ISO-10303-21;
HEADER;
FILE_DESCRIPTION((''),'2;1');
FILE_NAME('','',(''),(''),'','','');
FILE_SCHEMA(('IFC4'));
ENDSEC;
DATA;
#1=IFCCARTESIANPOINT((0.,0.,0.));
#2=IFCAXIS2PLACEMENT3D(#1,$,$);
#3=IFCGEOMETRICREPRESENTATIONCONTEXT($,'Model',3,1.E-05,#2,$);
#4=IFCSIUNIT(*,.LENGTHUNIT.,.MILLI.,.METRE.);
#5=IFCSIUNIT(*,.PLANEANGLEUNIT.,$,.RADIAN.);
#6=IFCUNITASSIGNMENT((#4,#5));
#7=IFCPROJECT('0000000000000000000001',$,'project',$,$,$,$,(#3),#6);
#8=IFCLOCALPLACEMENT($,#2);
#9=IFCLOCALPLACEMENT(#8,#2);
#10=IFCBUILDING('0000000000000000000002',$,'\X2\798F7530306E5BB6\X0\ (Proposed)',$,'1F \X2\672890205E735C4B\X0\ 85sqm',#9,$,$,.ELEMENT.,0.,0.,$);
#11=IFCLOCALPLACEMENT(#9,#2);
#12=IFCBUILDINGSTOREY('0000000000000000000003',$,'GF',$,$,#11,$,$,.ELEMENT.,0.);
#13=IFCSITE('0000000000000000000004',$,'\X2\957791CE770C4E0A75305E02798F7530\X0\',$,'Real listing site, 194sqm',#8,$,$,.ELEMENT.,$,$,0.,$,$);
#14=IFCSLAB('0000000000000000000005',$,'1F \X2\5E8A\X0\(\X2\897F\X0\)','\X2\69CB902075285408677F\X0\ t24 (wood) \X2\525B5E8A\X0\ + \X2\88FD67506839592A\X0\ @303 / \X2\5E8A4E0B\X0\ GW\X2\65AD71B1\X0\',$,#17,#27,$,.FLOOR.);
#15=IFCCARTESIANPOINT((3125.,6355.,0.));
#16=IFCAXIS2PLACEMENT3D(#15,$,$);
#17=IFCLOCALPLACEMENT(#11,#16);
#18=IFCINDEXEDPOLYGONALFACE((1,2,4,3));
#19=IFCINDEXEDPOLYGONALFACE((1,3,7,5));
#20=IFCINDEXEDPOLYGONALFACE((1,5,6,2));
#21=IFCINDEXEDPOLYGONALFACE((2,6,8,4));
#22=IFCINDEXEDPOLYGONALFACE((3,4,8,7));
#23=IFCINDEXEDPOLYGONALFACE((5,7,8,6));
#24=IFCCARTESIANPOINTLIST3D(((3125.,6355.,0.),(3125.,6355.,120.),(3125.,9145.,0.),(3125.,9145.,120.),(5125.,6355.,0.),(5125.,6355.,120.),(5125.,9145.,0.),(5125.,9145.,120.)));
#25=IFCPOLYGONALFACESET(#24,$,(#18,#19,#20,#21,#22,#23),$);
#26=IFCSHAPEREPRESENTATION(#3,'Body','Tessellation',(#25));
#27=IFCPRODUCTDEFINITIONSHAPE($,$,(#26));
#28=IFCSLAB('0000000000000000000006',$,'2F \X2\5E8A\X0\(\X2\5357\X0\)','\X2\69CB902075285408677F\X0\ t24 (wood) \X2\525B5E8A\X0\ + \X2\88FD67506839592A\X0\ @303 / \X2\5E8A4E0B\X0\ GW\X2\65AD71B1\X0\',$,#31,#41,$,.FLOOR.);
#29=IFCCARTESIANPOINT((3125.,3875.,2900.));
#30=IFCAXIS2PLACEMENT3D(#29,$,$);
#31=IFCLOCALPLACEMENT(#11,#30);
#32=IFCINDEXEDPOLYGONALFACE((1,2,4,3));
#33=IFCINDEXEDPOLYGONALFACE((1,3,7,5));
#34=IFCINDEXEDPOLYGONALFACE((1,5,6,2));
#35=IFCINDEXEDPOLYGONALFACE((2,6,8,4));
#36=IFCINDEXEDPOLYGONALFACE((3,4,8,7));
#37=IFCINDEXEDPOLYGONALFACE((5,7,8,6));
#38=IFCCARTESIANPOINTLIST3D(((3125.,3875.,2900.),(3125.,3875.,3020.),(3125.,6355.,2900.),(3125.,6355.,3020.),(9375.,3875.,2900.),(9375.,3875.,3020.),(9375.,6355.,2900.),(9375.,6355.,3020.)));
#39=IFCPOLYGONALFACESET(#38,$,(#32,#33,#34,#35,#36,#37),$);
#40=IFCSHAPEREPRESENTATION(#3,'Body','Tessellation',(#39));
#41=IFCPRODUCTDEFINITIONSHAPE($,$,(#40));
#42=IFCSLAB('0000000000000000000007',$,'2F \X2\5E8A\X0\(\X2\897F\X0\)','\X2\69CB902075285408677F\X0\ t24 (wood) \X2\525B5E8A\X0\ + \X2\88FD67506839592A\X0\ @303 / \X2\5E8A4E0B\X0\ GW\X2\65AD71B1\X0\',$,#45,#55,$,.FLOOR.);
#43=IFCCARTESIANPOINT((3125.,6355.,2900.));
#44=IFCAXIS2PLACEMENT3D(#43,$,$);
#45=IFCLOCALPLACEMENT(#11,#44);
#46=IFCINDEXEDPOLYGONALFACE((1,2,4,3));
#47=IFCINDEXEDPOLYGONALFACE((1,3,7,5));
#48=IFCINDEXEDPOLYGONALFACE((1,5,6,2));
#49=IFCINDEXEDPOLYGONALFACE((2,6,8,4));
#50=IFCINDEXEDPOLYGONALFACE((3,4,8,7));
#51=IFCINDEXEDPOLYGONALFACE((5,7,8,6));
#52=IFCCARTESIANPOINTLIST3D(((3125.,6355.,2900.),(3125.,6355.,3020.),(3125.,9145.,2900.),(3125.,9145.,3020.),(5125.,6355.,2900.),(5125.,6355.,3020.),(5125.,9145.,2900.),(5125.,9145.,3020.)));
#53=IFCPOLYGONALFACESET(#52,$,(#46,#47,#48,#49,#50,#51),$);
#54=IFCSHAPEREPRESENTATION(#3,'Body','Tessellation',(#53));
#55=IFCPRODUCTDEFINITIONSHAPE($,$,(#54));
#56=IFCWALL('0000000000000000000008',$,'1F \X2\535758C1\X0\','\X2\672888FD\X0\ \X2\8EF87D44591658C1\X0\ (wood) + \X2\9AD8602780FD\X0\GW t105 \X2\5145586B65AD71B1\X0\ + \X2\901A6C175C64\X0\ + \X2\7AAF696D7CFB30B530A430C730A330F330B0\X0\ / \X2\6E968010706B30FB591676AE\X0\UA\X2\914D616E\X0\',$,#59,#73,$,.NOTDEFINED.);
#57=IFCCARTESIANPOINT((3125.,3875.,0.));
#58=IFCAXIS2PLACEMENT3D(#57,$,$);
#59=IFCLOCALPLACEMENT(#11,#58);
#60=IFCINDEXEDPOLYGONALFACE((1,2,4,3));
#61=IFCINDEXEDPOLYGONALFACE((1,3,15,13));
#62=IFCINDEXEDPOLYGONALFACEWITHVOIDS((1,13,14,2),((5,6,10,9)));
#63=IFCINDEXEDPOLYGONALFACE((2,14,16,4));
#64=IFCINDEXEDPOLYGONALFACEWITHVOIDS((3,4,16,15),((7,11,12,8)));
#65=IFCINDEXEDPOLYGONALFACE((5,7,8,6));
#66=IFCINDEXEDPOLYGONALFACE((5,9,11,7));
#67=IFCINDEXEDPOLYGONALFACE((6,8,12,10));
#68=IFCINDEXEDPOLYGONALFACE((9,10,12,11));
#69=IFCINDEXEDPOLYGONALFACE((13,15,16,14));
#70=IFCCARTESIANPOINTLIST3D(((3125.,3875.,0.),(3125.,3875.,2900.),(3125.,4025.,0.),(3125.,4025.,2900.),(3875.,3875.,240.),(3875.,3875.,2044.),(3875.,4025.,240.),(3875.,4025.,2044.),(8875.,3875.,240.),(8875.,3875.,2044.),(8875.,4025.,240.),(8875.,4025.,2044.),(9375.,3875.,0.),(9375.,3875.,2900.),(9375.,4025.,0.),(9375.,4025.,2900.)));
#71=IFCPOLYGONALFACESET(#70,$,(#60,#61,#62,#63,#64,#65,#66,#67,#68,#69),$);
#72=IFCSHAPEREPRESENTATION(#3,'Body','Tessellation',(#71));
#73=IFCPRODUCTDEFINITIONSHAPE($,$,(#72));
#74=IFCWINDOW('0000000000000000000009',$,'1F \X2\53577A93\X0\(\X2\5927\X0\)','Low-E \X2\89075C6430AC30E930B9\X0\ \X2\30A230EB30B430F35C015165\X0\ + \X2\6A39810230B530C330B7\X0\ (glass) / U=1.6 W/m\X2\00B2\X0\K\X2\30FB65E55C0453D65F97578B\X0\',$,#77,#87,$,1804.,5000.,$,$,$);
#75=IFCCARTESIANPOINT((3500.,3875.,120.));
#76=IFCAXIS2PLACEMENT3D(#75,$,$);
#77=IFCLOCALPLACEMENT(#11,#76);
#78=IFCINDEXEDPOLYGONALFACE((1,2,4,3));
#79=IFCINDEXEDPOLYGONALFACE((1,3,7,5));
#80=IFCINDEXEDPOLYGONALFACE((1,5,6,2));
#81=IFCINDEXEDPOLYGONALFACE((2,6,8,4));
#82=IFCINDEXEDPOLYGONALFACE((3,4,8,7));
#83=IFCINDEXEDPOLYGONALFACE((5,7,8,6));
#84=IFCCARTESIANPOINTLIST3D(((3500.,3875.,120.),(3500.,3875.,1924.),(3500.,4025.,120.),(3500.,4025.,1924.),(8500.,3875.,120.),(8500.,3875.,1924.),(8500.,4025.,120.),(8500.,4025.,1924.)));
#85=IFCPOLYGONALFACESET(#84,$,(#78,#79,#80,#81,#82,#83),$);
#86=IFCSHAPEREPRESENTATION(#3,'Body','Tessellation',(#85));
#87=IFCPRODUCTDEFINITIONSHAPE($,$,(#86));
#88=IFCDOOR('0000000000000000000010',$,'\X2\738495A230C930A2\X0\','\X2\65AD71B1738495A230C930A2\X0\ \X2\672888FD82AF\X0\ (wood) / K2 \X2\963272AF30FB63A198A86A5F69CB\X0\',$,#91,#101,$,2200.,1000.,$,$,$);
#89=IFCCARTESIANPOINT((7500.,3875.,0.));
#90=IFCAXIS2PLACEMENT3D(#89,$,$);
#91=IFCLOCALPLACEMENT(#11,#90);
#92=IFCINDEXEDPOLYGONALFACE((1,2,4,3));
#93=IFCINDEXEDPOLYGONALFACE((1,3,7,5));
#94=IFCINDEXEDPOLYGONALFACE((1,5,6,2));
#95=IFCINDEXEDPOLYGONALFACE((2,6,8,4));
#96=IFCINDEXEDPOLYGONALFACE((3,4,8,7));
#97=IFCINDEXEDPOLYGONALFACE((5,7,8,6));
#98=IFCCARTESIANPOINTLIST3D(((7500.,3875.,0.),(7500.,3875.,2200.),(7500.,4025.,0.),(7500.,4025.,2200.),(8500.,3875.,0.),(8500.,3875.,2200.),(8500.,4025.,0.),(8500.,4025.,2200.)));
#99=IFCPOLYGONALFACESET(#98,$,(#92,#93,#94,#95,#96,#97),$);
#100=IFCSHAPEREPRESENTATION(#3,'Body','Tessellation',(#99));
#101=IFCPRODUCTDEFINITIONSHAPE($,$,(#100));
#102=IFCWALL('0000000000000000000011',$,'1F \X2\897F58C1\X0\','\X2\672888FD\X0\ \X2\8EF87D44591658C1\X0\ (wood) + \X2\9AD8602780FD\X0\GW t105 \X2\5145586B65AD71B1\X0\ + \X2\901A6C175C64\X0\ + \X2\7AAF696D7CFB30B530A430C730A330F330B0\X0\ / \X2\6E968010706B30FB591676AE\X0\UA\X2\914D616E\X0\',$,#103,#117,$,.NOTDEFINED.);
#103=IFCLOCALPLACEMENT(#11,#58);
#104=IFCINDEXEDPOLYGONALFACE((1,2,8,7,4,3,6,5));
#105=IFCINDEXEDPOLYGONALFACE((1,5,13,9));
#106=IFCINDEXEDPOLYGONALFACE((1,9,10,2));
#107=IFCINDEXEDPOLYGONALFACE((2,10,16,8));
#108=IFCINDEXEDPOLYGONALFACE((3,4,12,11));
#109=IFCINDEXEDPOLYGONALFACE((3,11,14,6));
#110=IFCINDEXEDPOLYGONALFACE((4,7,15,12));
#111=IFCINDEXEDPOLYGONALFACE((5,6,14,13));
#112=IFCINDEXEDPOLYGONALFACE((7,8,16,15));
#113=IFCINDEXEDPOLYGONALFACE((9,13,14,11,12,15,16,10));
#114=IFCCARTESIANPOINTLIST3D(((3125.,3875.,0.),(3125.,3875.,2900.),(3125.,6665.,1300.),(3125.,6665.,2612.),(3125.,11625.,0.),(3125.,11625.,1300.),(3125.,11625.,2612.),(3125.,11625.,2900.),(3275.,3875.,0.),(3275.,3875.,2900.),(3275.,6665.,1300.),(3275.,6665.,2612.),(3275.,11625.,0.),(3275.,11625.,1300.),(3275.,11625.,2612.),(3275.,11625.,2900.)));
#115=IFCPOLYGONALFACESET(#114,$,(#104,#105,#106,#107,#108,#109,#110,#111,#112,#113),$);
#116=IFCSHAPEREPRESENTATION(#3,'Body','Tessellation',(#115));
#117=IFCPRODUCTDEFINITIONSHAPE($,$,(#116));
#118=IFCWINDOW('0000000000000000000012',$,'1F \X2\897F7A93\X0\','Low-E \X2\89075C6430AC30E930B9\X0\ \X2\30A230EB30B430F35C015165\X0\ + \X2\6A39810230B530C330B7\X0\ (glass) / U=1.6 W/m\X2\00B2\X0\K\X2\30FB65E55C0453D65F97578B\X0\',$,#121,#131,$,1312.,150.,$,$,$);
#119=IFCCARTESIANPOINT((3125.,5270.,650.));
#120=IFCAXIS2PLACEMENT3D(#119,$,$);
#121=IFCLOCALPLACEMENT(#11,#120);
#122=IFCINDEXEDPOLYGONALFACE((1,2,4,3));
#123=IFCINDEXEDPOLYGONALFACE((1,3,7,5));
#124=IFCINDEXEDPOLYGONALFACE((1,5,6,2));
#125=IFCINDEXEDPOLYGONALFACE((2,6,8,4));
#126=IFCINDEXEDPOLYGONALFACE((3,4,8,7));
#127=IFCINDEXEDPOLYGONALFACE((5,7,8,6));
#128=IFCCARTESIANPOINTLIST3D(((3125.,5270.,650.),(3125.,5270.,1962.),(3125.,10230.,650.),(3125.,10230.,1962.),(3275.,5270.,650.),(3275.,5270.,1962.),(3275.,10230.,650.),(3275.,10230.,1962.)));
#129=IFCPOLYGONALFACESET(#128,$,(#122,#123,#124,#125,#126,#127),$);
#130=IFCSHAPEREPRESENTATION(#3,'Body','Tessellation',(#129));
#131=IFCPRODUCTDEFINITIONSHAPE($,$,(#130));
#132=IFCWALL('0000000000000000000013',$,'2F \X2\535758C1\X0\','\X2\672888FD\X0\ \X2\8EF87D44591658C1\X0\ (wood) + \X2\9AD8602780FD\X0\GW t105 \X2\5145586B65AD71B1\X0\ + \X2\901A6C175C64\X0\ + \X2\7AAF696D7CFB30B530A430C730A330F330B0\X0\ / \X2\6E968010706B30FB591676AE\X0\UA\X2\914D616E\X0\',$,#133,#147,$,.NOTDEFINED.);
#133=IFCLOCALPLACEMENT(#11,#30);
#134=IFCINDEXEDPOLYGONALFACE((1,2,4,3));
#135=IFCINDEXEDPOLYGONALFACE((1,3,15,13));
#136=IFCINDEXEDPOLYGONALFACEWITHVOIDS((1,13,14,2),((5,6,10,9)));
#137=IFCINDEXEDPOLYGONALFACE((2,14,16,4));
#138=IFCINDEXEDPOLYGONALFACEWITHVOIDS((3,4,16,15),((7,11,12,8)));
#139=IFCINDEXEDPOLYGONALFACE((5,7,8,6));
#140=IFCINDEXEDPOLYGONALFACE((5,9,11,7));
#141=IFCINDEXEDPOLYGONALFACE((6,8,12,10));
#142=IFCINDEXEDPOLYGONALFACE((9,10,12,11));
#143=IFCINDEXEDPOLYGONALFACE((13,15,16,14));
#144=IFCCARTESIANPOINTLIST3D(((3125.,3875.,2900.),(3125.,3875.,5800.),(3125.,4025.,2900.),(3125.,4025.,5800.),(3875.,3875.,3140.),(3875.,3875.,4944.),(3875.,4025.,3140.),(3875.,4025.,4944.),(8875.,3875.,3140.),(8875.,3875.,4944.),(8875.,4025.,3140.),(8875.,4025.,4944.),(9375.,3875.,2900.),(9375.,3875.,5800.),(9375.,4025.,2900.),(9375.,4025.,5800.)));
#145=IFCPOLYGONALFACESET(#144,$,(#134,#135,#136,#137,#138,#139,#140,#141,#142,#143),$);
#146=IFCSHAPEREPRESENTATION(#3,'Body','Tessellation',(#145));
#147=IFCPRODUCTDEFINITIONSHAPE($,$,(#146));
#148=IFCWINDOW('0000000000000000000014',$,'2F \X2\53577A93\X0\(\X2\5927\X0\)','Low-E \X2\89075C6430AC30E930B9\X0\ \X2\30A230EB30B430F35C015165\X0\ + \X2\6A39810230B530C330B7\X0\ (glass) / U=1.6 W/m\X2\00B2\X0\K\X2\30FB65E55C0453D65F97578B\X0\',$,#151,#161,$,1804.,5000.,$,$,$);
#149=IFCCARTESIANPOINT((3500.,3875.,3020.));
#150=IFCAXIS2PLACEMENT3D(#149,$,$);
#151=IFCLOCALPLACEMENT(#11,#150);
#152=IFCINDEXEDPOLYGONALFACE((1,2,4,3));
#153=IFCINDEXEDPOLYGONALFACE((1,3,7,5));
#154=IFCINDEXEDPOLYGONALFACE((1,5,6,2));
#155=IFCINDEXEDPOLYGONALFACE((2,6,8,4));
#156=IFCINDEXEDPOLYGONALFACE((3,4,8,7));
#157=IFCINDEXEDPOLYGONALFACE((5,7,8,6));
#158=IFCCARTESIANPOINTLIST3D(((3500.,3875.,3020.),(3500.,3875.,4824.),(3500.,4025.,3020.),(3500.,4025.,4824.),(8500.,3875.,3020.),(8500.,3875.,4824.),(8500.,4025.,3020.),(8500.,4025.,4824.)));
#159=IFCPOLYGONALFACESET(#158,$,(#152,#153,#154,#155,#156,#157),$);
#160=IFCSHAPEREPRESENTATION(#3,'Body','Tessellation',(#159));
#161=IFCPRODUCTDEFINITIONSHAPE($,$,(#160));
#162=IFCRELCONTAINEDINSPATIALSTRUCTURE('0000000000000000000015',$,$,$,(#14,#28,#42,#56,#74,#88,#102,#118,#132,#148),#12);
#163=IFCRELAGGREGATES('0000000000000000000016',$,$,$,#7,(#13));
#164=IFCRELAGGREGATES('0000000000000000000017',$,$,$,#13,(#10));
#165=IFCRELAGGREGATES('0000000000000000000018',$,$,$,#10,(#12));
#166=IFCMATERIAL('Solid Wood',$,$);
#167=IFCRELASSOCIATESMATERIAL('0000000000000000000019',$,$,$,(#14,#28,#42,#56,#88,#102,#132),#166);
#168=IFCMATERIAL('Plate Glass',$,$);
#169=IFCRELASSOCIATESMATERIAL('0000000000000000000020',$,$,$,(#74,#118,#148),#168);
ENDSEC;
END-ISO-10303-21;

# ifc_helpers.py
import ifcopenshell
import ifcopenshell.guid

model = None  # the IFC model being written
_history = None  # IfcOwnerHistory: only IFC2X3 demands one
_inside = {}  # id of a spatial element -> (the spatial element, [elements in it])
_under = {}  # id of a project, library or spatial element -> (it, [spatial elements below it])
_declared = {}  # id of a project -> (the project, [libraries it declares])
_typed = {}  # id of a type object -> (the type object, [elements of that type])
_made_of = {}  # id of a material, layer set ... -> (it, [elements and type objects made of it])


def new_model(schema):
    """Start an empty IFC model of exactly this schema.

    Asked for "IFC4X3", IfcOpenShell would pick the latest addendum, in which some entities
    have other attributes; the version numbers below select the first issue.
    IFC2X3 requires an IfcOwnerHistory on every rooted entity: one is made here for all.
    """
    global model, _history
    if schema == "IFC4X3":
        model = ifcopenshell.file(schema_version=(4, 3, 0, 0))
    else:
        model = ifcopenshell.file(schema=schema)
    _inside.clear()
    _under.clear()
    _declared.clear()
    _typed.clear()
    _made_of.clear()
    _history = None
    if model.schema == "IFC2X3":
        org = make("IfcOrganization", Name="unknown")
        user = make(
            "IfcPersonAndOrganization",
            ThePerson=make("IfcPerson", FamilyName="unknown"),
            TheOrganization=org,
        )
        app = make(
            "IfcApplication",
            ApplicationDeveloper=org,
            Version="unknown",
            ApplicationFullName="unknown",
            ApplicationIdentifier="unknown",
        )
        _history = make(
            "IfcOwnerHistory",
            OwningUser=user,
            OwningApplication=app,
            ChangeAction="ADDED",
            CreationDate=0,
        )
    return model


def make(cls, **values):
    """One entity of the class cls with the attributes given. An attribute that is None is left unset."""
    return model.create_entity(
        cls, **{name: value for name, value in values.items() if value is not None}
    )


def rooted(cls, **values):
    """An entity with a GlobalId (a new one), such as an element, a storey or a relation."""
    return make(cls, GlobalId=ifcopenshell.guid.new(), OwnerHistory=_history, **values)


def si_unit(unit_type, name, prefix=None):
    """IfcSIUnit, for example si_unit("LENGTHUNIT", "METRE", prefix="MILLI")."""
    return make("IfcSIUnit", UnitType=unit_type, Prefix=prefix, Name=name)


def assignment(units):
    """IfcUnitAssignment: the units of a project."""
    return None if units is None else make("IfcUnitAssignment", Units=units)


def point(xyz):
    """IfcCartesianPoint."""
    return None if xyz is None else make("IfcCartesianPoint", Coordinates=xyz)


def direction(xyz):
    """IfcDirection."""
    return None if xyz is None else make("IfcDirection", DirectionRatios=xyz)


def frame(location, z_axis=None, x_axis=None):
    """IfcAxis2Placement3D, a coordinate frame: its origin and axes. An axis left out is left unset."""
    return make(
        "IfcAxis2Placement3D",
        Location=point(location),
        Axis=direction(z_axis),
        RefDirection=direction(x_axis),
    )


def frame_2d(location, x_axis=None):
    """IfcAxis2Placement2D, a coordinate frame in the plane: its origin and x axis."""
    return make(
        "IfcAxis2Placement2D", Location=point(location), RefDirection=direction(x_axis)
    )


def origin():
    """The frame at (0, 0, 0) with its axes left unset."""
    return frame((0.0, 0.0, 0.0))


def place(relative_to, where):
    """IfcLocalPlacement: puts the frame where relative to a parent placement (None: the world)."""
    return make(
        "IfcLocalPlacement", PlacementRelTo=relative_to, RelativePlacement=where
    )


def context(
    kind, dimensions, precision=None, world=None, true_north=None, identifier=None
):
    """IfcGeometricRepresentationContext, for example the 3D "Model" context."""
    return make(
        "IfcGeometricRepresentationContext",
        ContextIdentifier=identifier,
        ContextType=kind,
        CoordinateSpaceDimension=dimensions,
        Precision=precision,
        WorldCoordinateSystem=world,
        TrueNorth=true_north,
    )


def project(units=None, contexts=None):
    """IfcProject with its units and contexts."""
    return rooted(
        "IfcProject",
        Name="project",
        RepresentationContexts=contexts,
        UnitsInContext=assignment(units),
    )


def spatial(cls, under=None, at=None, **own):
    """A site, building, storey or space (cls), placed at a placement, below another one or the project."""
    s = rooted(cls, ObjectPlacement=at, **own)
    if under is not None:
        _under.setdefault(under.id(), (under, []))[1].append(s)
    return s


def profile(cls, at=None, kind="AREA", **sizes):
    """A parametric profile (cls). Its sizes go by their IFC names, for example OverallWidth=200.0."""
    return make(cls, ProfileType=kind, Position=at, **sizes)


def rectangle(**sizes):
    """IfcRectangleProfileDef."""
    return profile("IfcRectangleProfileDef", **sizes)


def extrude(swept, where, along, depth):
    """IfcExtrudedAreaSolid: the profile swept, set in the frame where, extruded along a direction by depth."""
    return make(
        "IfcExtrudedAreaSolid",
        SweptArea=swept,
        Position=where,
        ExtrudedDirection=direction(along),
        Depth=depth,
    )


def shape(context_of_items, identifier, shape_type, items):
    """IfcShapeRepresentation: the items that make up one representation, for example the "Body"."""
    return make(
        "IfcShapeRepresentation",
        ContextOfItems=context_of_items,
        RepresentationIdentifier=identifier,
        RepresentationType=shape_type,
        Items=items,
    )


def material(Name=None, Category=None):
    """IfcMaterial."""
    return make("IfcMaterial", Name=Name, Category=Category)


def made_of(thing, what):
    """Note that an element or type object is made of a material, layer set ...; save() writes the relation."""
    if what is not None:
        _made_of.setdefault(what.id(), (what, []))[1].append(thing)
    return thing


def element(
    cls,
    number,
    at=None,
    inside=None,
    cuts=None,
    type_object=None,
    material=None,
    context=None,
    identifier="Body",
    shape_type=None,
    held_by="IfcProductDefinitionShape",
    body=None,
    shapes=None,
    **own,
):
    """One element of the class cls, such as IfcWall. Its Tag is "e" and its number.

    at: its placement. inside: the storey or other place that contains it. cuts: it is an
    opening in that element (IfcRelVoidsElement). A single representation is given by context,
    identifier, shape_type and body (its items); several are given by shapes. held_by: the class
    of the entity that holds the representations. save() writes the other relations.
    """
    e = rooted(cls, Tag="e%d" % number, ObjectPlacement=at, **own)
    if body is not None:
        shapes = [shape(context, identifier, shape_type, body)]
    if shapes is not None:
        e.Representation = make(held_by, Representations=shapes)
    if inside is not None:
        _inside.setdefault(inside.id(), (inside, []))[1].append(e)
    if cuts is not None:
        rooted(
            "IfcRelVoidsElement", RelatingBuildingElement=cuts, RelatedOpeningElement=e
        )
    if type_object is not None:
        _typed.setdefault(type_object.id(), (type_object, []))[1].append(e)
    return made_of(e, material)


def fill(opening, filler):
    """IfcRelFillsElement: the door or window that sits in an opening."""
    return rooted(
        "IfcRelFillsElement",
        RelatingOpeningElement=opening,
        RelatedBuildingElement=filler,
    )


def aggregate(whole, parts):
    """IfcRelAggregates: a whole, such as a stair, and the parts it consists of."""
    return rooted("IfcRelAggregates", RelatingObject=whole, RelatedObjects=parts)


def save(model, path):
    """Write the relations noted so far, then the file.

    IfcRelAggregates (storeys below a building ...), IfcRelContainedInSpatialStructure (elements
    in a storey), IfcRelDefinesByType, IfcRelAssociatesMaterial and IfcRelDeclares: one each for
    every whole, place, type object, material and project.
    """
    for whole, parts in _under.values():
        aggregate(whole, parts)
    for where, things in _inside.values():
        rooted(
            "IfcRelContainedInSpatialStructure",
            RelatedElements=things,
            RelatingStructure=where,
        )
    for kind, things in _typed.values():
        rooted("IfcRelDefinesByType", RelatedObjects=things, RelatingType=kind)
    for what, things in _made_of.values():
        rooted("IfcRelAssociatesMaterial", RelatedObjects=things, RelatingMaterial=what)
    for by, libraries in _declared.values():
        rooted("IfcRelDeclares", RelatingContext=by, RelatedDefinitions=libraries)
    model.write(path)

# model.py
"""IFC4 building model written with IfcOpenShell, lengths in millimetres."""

from ifc_helpers import new_model, si_unit, frame, frame_2d, origin, place, context, project, spatial, rectangle, extrude, material, element, fill, save


model = new_model("IFC4")

# Units and contexts
model_context = context("Model", 3, precision=1e-05, world=origin())
ifc_project = project(units=[si_unit("LENGTHUNIT", "METRE", prefix="MILLI"), si_unit("PLANEANGLEUNIT", "RADIAN")], contexts=[model_context])

# Site, building, storey
site_placement = place(None, origin())
site = spatial("IfcSite", under=ifc_project, at=site_placement, Name="長野県上田市福田", ObjectType="Real listing site, 194sqm", CompositionType="ELEMENT", RefElevation=0.0)
building_placement = place(site_placement, origin())
building = spatial("IfcBuilding", under=site, at=building_placement, Name="福田の家 (Proposed)", ObjectType="1F 木造平屋 85sqm", CompositionType="ELEMENT", ElevationOfRefHeight=0.0, ElevationOfTerrain=0.0)
storey_placement = place(building_placement, origin())
storey = spatial("IfcBuildingStorey", under=building, at=storey_placement, Name="GF", CompositionType="ELEMENT", Elevation=0.0)

# Slabs
ifc_material_1 = material(Name="Solid Wood")
slab_1_placement = place(storey_placement, frame((3125.0, 6355.0, 0.0)))
element("IfcSlab", 1, at=slab_1_placement, inside=storey, material=ifc_material_1, Name="1F 床(西)", Description="構造用合板 t24 (wood) 剛床 + 製材根太 @303 / 床下 GW断熱", PredefinedType="FLOOR", context=model_context, shape_type="SweptSolid", body=[
    extrude(rectangle(XDim=2000.0, YDim=2790.0, at=frame_2d((1000.0, 1395.0))), frame((3125.0, 6355.0, 0.0)), (0.0, 0.0, 1.0), 120.0),
])
slab_2_placement = place(storey_placement, frame((3125.0, 3875.0, 2900.0)))
element("IfcSlab", 2, at=slab_2_placement, inside=storey, material=ifc_material_1, Name="2F 床(南)", Description="構造用合板 t24 (wood) 剛床 + 製材根太 @303 / 床下 GW断熱", PredefinedType="FLOOR", context=model_context, shape_type="SweptSolid", body=[
    extrude(rectangle(XDim=6250.0, YDim=2480.0, at=frame_2d((3125.0, 1240.0))), frame((3125.0, 3875.0, 2900.0)), (0.0, 0.0, 1.0), 120.0),
])
slab_3_placement = place(storey_placement, frame((3125.0, 6355.0, 2900.0)))
element("IfcSlab", 3, at=slab_3_placement, inside=storey, material=ifc_material_1, Name="2F 床(西)", Description="構造用合板 t24 (wood) 剛床 + 製材根太 @303 / 床下 GW断熱", PredefinedType="FLOOR", context=model_context, shape_type="SweptSolid", body=[
    extrude(rectangle(XDim=2000.0, YDim=2790.0, at=frame_2d((1000.0, 1395.0))), frame((3125.0, 6355.0, 2900.0)), (0.0, 0.0, 1.0), 120.0),
])

# Wall, openings, window, door
wall_1_placement = place(storey_placement, frame((3125.0, 3875.0, 0.0)))
wall_1 = element("IfcWall", 4, at=wall_1_placement, inside=storey, material=ifc_material_1, Name="1F 南壁", Description="木製 軸組外壁 (wood) + 高性能GW t105 充填断熱 + 通気層 + 窯業系サイディング / 準耐火・外皮UA配慮", PredefinedType="NOTDEFINED", context=model_context, shape_type="SweptSolid", body=[
    extrude(rectangle(XDim=6250.0, YDim=150.0, at=frame_2d((3125.0, 75.0))), frame((3125.0, 3875.0, 0.0)), (0.0, 0.0, 1.0), 2900.0),
])
opening_1_placement = place(storey_placement, frame((3500.0, 3875.0, 120.0)))
opening_1 = element("IfcOpeningElement", 5, at=opening_1_placement, cuts=wall_1, PredefinedType="NOTDEFINED", context=model_context, shape_type="SweptSolid", body=[
    extrude(rectangle(XDim=5000.0, YDim=150.0, at=frame_2d((2500.0, 75.0))), frame((3500.0, 3875.0, 120.0)), (0.0, 0.0, 1.0), 1804.0),
])
opening_2_placement = place(storey_placement, frame((7500.0, 3875.0, 0.0)))
opening_2 = element("IfcOpeningElement", 6, at=opening_2_placement, cuts=wall_1, PredefinedType="NOTDEFINED", context=model_context, shape_type="SweptSolid", body=[
    extrude(rectangle(XDim=1000.0, YDim=150.0, at=frame_2d((500.0, 75.0))), frame((7500.0, 3875.0, 0.0)), (0.0, 0.0, 1.0), 2200.0),
])
ifc_material_2 = material(Name="Plate Glass")
window_1_placement = place(storey_placement, frame((3500.0, 3875.0, 120.0)))
window_1 = element("IfcWindow", 7, at=window_1_placement, inside=storey, material=ifc_material_2, Name="1F 南窓(大)", Description="Low-E 複層ガラス アルゴン封入 + 樹脂サッシ (glass) / U=1.6 W/m²K・日射取得型", OverallHeight=1804.0, OverallWidth=5000.0, context=model_context, shape_type="SweptSolid", body=[
    extrude(rectangle(XDim=5000.0, YDim=150.0, at=frame_2d((2500.0, 75.0))), frame((3500.0, 3875.0, 120.0)), (0.0, 0.0, 1.0), 1804.0),
])
fill(opening_1, window_1)
door_placement = place(storey_placement, frame((7500.0, 3875.0, 0.0)))
door = element("IfcDoor", 8, at=door_placement, inside=storey, material=ifc_material_1, Name="玄関ドア", Description="断熱玄関ドア 木製芯 (wood) / K2 防犯・採風機構", OverallHeight=2200.0, OverallWidth=1000.0, context=model_context, shape_type="SweptSolid", body=[
    extrude(rectangle(XDim=1000.0, YDim=150.0, at=frame_2d((500.0, 75.0))), frame((7500.0, 3875.0, 0.0)), (0.0, 0.0, 1.0), 2200.0),
])
fill(opening_2, door)

# Walls, openings, windows
wall_2_placement = place(storey_placement, frame((3125.0, 3875.0, 0.0)))
wall_2 = element("IfcWall", 9, at=wall_2_placement, inside=storey, material=ifc_material_1, Name="1F 西壁", Description="木製 軸組外壁 (wood) + 高性能GW t105 充填断熱 + 通気層 + 窯業系サイディング / 準耐火・外皮UA配慮", PredefinedType="NOTDEFINED", context=model_context, shape_type="SweptSolid", body=[
    extrude(rectangle(XDim=150.0, YDim=7750.0, at=frame_2d((75.0, 3875.0))), frame((3125.0, 3875.0, 0.0)), (0.0, 0.0, 1.0), 2900.0),
])
opening_3_placement = place(storey_placement, frame((3125.0, 5270.0, 650.0)))
opening_3 = element("IfcOpeningElement", 10, at=opening_3_placement, cuts=wall_2, PredefinedType="NOTDEFINED", context=model_context, shape_type="SweptSolid", body=[
    extrude(rectangle(XDim=150.0, YDim=4960.0, at=frame_2d((75.0, 2480.0))), frame((3125.0, 5270.0, 650.0)), (0.0, 0.0, 1.0), 1312.0),
])
window_2_placement = place(storey_placement, frame((3125.0, 5270.0, 650.0)))
window_2 = element("IfcWindow", 11, at=window_2_placement, inside=storey, material=ifc_material_2, Name="1F 西窓", Description="Low-E 複層ガラス アルゴン封入 + 樹脂サッシ (glass) / U=1.6 W/m²K・日射取得型", OverallHeight=1312.0, OverallWidth=150.0, context=model_context, shape_type="SweptSolid", body=[
    extrude(rectangle(XDim=150.0, YDim=4960.0, at=frame_2d((75.0, 2480.0))), frame((3125.0, 5270.0, 650.0)), (0.0, 0.0, 1.0), 1312.0),
])
fill(opening_3, window_2)
wall_3_placement = place(storey_placement, frame((3125.0, 3875.0, 2900.0)))
wall_3 = element("IfcWall", 12, at=wall_3_placement, inside=storey, material=ifc_material_1, Name="2F 南壁", Description="木製 軸組外壁 (wood) + 高性能GW t105 充填断熱 + 通気層 + 窯業系サイディング / 準耐火・外皮UA配慮", PredefinedType="NOTDEFINED", context=model_context, shape_type="SweptSolid", body=[
    extrude(rectangle(XDim=6250.0, YDim=150.0, at=frame_2d((3125.0, 75.0))), frame((3125.0, 3875.0, 2900.0)), (0.0, 0.0, 1.0), 2900.0),
])
opening_4_placement = place(storey_placement, frame((3500.0, 3875.0, 3020.0)))
opening_4 = element("IfcOpeningElement", 13, at=opening_4_placement, cuts=wall_3, PredefinedType="NOTDEFINED", context=model_context, shape_type="SweptSolid", body=[
    extrude(rectangle(XDim=5000.0, YDim=150.0, at=frame_2d((2500.0, 75.0))), frame((3500.0, 3875.0, 3020.0)), (0.0, 0.0, 1.0), 1804.0),
])
window_3_placement = place(storey_placement, frame((3500.0, 3875.0, 3020.0)))
window_3 = element("IfcWindow", 14, at=window_3_placement, inside=storey, material=ifc_material_2, Name="2F 南窓(大)", Description="Low-E 複層ガラス アルゴン封入 + 樹脂サッシ (glass) / U=1.6 W/m²K・日射取得型", OverallHeight=1804.0, OverallWidth=5000.0, context=model_context, shape_type="SweptSolid", body=[
    extrude(rectangle(XDim=5000.0, YDim=150.0, at=frame_2d((2500.0, 75.0))), frame((3500.0, 3875.0, 3020.0)), (0.0, 0.0, 1.0), 1804.0),
])
fill(opening_4, window_3)

save(model, "model.ifc")
